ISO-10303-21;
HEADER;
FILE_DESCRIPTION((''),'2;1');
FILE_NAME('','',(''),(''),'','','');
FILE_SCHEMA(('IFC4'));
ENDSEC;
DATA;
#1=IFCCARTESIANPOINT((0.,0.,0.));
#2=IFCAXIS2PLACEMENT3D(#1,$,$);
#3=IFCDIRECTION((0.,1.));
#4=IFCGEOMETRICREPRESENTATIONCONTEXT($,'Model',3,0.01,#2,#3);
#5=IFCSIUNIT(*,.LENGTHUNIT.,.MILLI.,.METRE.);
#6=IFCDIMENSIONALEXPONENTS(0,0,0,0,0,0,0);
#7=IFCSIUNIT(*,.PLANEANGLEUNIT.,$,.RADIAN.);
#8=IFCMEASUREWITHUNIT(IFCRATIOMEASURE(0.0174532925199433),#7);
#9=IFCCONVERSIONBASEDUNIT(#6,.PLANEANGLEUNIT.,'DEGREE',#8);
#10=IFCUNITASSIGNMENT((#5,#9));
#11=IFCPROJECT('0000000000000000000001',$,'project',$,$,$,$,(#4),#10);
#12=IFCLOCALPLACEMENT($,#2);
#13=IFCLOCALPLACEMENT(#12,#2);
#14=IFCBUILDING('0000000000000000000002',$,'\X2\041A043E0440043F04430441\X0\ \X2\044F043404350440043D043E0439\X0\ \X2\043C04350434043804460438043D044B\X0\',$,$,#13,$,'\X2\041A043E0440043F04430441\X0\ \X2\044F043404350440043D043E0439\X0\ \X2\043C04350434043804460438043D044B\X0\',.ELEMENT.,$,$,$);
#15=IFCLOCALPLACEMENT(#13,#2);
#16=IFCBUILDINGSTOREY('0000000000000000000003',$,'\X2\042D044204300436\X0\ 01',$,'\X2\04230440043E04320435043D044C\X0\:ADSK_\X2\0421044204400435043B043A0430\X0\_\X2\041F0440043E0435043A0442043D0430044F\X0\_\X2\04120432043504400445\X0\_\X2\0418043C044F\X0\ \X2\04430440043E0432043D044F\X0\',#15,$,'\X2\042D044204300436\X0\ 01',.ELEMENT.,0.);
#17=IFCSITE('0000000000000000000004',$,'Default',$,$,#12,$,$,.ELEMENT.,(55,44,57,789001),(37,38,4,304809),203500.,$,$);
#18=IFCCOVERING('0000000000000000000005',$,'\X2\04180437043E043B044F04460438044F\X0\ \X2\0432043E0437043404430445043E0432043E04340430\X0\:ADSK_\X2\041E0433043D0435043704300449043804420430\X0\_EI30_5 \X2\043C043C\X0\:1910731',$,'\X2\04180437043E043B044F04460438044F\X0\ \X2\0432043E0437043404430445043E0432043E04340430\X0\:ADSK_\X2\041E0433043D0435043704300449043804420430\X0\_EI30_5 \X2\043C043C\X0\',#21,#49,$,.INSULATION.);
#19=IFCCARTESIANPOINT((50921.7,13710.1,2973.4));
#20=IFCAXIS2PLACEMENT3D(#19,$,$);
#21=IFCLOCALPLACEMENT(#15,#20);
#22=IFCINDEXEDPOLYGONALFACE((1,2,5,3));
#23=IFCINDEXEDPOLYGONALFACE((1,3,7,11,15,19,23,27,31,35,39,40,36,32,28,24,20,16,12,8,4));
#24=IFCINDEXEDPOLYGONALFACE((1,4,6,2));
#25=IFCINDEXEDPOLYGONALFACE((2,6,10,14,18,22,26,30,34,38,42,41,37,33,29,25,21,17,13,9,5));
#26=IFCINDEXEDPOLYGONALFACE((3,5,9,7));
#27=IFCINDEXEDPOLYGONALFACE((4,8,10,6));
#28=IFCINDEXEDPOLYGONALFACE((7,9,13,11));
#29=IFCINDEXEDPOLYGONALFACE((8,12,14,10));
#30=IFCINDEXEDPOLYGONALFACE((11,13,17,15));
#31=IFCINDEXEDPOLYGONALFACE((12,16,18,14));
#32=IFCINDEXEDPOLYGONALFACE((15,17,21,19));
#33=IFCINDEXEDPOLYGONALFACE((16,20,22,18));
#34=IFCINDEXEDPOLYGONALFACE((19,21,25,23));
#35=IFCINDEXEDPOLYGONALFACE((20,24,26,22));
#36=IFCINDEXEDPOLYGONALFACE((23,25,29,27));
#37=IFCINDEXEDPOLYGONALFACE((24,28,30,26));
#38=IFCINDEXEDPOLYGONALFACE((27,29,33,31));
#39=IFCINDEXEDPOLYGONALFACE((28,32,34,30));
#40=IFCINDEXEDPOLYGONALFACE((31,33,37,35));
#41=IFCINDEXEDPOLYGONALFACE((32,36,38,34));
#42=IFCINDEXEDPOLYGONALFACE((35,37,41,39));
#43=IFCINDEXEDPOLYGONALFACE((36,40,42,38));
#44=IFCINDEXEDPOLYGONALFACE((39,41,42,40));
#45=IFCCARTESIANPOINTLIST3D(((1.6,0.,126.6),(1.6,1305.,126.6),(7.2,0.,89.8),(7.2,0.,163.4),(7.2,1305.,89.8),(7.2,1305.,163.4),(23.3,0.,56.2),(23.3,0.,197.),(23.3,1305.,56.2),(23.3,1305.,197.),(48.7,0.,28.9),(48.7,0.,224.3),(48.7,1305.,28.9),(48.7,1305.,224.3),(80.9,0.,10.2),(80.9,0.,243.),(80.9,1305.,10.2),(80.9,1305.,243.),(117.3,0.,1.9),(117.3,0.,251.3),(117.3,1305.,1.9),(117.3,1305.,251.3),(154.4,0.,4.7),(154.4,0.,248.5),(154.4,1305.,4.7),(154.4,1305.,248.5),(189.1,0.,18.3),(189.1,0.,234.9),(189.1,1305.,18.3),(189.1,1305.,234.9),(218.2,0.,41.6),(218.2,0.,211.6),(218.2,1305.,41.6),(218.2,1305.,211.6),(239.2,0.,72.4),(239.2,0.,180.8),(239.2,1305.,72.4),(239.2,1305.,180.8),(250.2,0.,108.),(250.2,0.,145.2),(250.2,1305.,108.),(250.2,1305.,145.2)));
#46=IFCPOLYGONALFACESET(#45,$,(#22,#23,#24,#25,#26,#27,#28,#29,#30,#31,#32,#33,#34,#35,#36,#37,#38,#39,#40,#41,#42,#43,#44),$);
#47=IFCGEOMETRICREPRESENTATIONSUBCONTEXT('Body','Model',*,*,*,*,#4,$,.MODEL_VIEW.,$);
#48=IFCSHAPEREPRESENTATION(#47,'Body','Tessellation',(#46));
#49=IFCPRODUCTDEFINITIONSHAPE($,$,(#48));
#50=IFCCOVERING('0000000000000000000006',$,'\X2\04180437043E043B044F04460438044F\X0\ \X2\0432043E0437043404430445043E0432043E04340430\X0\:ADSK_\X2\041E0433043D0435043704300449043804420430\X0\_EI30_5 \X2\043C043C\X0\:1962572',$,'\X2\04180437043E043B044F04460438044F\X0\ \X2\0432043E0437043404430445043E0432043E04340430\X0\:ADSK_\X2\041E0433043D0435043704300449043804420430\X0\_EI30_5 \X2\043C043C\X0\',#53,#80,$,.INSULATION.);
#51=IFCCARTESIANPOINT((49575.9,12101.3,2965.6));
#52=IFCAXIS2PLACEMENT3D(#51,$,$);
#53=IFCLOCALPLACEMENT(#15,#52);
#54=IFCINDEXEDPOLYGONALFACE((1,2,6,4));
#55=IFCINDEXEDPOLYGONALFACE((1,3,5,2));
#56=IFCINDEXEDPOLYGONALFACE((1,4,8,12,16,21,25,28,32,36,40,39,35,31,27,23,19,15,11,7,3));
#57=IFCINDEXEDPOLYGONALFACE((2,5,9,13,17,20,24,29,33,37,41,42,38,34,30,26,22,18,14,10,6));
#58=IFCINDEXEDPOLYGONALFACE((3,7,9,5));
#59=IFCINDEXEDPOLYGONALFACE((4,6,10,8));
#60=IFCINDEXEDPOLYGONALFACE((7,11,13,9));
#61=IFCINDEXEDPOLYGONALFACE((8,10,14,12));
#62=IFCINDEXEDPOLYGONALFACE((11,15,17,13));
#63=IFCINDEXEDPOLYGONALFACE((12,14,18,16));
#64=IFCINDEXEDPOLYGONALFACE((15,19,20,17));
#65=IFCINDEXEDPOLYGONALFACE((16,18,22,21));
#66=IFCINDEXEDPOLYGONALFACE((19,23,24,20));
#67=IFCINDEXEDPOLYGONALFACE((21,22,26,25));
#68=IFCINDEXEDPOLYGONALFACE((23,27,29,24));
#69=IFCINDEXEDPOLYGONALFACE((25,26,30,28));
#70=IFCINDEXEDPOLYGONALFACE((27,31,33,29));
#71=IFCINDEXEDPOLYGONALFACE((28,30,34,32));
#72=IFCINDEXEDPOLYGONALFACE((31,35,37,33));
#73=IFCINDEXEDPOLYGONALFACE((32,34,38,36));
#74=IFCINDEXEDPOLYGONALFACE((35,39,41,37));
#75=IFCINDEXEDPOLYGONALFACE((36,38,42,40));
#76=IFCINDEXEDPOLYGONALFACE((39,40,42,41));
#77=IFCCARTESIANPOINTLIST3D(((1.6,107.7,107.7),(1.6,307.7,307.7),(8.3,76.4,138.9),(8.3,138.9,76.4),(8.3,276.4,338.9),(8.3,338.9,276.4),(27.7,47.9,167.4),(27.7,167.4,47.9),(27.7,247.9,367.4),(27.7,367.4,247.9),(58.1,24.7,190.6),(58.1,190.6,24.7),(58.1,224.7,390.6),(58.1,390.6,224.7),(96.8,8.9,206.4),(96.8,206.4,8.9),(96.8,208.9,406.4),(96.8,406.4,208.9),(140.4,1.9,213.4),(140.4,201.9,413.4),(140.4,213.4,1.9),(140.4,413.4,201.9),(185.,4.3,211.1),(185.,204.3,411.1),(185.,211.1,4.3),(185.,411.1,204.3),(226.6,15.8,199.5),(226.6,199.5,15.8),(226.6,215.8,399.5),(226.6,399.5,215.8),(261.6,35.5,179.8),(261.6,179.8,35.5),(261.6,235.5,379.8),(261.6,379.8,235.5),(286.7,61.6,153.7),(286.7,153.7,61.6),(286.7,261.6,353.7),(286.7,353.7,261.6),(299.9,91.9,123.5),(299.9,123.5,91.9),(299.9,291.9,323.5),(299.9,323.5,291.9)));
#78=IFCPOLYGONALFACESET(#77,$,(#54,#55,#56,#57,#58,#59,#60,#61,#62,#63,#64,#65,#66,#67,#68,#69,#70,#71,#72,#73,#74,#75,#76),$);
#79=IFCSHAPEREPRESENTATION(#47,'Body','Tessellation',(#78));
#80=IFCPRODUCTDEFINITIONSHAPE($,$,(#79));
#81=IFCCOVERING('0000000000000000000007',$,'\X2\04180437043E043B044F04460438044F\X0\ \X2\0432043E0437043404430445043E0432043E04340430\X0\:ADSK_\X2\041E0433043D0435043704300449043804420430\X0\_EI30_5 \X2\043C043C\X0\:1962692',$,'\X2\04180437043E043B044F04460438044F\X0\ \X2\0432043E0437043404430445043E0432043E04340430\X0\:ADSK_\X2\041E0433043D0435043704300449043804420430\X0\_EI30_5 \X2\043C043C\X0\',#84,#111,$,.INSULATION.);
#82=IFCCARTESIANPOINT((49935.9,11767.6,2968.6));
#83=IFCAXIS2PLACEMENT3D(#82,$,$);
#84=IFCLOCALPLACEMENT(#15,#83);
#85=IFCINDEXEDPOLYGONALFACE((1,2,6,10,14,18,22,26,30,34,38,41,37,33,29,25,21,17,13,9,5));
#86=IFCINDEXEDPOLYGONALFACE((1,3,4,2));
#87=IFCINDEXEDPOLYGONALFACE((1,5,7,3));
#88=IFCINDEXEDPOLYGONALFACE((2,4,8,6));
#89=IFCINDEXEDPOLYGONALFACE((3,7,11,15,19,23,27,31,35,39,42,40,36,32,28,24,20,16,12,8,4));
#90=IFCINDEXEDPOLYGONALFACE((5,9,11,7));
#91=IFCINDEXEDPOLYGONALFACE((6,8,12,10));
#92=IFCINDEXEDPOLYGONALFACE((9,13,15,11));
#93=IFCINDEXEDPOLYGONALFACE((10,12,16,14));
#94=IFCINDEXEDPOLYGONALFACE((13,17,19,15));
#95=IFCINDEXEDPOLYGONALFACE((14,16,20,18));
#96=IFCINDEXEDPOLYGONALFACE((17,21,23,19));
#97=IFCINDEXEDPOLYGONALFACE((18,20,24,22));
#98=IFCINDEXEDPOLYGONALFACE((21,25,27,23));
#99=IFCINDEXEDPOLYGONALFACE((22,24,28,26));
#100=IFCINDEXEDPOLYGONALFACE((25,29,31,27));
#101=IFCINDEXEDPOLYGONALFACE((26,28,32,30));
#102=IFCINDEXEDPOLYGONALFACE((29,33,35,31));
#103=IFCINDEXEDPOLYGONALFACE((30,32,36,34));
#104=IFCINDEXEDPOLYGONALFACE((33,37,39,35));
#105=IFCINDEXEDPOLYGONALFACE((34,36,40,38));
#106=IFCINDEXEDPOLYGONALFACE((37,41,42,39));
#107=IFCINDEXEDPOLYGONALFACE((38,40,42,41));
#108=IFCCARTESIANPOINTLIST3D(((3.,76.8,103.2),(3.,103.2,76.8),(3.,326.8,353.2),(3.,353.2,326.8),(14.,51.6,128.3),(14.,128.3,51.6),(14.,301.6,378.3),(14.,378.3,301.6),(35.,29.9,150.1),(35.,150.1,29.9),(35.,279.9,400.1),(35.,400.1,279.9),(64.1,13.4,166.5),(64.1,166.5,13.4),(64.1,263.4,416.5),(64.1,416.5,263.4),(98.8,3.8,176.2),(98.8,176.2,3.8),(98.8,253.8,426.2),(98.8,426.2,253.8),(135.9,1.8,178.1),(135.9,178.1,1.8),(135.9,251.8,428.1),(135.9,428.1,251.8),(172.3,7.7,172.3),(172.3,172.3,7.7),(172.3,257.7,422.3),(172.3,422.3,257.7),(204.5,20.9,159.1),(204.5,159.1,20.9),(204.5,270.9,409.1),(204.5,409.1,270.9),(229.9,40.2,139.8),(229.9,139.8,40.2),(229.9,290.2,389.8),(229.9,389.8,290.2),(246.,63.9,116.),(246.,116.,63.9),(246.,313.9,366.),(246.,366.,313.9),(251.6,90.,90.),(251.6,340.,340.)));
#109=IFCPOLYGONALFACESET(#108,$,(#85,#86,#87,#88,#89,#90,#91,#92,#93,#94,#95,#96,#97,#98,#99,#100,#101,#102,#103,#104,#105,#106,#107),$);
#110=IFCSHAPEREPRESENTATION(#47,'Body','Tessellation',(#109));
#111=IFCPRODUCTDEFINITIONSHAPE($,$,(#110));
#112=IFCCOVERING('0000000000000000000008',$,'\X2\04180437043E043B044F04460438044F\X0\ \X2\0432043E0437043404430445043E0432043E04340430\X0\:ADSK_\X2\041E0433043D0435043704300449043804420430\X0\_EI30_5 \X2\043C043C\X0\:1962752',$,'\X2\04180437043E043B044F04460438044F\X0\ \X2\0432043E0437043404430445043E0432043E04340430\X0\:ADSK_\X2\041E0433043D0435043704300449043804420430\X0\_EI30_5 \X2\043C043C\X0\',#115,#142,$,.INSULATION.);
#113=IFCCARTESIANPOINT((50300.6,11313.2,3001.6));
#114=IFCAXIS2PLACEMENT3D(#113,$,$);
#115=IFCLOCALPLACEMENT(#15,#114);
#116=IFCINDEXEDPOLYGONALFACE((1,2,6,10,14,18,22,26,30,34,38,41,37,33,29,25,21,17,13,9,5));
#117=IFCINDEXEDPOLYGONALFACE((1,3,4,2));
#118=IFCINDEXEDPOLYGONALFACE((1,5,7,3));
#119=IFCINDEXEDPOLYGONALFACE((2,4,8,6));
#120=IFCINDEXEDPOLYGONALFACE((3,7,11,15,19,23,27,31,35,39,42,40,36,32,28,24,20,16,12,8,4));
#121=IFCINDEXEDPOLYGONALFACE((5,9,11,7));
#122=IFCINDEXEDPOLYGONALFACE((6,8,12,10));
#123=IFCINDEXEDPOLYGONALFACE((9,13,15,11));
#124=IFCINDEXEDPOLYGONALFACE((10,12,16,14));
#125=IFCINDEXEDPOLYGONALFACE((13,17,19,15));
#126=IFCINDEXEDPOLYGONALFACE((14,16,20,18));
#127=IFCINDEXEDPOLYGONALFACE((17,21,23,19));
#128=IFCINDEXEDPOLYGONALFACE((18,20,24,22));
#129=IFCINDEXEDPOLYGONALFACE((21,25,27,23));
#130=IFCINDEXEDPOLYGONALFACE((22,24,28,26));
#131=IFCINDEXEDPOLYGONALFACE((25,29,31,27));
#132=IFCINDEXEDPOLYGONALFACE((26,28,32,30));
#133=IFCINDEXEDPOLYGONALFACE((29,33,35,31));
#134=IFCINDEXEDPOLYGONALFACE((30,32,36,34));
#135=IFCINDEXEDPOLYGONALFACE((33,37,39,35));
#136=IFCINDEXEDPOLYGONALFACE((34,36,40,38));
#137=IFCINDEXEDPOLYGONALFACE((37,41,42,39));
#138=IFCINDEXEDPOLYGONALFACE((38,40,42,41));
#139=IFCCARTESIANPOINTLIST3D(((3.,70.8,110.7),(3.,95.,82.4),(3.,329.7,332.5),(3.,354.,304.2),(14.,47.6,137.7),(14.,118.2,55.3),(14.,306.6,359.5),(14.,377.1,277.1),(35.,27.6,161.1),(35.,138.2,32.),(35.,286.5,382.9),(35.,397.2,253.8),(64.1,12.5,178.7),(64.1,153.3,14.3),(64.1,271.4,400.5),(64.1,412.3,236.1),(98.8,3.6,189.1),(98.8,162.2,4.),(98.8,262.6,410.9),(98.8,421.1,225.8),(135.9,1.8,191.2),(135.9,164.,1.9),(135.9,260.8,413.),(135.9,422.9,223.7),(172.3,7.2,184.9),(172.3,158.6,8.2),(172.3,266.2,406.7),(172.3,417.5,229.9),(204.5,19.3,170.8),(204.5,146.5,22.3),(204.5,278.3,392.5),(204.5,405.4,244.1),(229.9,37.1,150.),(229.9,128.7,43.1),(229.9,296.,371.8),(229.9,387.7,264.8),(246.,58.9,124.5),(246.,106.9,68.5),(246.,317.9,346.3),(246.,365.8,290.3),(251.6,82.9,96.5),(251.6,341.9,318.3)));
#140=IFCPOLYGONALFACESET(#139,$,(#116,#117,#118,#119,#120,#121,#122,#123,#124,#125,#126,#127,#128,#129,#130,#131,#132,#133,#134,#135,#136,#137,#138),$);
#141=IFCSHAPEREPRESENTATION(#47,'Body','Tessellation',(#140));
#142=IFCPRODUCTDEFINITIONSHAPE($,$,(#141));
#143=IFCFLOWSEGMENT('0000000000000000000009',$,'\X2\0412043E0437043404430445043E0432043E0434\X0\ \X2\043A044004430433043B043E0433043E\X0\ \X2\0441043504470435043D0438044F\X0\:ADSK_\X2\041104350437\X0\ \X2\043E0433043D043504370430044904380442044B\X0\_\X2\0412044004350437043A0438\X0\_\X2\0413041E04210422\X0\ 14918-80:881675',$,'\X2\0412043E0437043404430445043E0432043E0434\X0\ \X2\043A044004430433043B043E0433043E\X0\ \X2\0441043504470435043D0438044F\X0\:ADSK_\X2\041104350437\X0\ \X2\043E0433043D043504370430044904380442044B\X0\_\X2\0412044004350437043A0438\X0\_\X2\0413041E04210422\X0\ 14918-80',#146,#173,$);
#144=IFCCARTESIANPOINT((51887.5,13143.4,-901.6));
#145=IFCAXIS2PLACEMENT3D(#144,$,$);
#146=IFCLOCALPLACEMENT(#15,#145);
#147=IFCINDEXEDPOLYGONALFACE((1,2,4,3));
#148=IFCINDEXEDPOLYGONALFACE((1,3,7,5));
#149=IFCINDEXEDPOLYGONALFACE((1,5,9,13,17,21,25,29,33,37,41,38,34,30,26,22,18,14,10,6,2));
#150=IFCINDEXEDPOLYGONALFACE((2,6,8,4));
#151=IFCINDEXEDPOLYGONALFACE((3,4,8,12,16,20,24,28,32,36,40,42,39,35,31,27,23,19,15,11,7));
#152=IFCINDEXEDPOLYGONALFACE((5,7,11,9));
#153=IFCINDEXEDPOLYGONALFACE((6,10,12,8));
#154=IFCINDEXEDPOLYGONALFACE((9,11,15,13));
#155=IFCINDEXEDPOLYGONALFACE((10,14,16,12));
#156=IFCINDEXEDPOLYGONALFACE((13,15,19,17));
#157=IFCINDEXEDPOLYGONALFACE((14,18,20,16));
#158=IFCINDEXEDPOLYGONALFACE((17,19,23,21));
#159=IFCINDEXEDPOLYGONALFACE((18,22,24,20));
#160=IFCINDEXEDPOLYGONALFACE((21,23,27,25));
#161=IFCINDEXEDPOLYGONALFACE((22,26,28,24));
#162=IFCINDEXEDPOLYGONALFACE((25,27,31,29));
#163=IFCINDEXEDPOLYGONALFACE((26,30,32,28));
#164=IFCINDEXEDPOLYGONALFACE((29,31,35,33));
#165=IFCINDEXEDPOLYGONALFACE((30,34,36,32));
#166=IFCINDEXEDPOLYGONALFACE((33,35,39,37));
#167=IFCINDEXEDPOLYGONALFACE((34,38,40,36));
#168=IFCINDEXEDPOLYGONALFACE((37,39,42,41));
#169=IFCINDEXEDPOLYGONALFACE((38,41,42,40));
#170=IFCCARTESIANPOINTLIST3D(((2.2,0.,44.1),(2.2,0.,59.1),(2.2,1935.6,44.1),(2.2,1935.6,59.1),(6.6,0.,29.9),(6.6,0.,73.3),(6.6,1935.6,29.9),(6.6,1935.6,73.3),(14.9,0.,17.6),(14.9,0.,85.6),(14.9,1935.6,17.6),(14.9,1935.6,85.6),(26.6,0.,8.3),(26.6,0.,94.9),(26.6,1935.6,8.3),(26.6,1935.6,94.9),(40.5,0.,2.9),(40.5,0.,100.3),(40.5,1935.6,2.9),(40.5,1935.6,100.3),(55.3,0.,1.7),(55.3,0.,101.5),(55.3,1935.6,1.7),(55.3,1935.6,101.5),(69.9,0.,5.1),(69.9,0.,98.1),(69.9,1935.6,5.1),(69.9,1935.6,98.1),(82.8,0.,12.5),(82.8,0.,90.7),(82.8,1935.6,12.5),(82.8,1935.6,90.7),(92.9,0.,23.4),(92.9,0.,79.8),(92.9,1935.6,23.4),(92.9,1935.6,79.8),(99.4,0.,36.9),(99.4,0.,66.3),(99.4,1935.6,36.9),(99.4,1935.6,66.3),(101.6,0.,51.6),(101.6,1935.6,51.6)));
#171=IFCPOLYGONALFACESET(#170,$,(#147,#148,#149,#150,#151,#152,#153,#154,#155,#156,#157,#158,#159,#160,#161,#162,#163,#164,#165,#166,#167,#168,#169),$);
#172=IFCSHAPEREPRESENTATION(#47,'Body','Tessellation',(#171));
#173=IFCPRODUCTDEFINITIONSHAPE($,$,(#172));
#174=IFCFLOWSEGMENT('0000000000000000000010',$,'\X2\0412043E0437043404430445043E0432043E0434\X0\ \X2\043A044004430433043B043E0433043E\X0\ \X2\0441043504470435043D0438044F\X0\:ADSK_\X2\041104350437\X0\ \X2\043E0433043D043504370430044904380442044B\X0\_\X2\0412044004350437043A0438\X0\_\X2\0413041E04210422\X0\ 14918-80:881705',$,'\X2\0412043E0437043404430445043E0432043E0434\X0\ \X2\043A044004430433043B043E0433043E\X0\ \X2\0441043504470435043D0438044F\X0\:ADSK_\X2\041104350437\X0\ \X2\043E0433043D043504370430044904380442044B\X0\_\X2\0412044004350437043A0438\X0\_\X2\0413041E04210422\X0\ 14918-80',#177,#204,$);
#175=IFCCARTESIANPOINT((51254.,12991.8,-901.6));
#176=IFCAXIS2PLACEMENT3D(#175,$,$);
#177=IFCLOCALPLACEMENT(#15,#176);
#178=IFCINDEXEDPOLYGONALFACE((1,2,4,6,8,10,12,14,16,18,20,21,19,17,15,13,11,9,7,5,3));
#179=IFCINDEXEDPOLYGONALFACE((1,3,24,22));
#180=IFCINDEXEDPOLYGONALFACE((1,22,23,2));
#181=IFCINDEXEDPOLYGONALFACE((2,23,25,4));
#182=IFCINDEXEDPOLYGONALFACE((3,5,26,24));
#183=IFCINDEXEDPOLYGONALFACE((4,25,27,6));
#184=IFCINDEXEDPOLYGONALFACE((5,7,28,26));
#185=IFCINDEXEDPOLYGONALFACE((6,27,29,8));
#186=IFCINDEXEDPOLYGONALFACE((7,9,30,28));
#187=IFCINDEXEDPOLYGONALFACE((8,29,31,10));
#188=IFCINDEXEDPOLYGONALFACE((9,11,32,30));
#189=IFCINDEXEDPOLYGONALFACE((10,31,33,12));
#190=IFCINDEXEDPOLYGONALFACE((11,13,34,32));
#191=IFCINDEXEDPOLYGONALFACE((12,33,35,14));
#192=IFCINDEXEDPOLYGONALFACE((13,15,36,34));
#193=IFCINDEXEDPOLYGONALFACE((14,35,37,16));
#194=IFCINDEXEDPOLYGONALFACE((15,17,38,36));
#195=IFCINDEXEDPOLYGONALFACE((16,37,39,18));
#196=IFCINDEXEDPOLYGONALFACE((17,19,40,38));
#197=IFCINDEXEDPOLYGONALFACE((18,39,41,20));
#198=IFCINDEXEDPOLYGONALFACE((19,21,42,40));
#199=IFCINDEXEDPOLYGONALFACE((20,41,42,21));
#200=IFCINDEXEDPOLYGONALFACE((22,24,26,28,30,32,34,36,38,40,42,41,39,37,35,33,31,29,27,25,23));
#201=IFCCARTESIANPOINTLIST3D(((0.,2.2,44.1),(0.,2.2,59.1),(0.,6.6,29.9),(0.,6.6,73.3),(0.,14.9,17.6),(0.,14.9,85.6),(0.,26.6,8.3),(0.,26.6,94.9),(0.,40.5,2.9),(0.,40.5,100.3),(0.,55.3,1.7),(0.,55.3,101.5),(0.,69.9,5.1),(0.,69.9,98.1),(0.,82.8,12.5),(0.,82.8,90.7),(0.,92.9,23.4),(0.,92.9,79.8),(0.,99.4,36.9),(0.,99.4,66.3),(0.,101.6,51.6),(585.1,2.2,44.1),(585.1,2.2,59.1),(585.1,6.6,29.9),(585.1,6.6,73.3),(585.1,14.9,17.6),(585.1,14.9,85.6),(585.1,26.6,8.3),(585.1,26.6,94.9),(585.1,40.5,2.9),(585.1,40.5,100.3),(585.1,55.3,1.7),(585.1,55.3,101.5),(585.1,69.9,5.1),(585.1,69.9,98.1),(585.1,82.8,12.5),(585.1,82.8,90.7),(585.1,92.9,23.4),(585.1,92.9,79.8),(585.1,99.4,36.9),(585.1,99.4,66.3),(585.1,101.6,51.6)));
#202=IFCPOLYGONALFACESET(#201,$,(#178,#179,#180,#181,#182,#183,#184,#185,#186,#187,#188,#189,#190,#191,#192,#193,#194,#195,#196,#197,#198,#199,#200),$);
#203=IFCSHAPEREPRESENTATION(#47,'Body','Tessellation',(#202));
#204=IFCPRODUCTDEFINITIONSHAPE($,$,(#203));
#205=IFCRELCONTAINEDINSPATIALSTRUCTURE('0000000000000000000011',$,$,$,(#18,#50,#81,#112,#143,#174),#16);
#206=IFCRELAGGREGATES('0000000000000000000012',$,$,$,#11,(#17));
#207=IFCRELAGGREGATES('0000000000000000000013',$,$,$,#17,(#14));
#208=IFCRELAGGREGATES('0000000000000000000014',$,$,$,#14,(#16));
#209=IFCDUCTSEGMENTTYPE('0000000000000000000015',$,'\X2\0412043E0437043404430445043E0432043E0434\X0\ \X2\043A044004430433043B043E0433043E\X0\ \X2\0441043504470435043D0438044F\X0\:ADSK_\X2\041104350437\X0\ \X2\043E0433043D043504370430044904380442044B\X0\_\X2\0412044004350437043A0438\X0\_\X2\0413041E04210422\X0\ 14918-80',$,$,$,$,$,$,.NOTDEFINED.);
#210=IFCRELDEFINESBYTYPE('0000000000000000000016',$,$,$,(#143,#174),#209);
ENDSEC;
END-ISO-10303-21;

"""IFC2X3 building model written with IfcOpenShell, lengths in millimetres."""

from ifc_helpers import new_model, entity, si_unit, converted_unit, direction, frame, origin, origin_2d_with_axis, place, context, subcontext, project, spatial, circle, extrude, type_object, element, save


model = new_model("IFC2X3")

# Units and contexts
model_context = context("Model", 3, precision=0.01, world=origin(), true_north=direction((0.0, 1.0)))
body_context = subcontext(model_context, "Body", "Model", "MODEL_VIEW")
ifc_project = project(units=[si_unit("LENGTHUNIT", "METRE", prefix="MILLI"), converted_unit("PLANEANGLEUNIT", "DEGREE", entity("IfcRatioMeasure", 0.0174532925199433), si_unit("PLANEANGLEUNIT", "RADIAN"), dimensions=[0, 0, 0, 0, 0, 0, 0])], contexts=[model_context])

# Site, building, storey
site_placement = place(None, origin())
site = spatial("IfcSite", under=ifc_project, at=site_placement, Name="Default", CompositionType="ELEMENT", RefLatitude=(55, 44, 57, 789001), RefLongitude=(37, 38, 4, 304809), RefElevation=203500.0)
building_placement = place(site_placement, origin())
building = spatial("IfcBuilding", under=site, at=building_placement, Name="Корпус ядерной медицины", LongName="Корпус ядерной медицины", CompositionType="ELEMENT")
storey_placement = place(building_placement, origin())
storey = spatial("IfcBuildingStorey", under=building, at=storey_placement, Name="Этаж 01", ObjectType="Уровень:ADSK_Стрелка_Проектная_Вверх_Имя уровня", LongName="Этаж 01", CompositionType="ELEMENT", Elevation=0.0)

# Coverings
covering_1_placement = place(storey_placement, frame((50921.7, 13710.1, 2973.4)))
element("IfcCovering", 1, at=covering_1_placement, inside=storey, Name="Изоляция воздуховода:ADSK_Огнезащита_EI30_5 мм:1910731", ObjectType="Изоляция воздуховода:ADSK_Огнезащита_EI30_5 мм", PredefinedType="INSULATION", context=body_context, shape_type="SweptSolid", body=[
    extrude(circle(Radius=125.0, at=origin_2d_with_axis()), frame((126.6, 0.0, 126.6), z_axis=(0.0, 1.0, 0.0), x_axis=(-1.0, 0.0, 0.0)), (0.0, 0.0, 1.0), 1305.0),
])
covering_2_placement = place(storey_placement, frame((49575.9, 12101.3, 2965.6)))
element("IfcCovering", 2, at=covering_2_placement, inside=storey, Name="Изоляция воздуховода:ADSK_Огнезащита_EI30_5 мм:1962572", ObjectType="Изоляция воздуховода:ADSK_Огнезащита_EI30_5 мм", PredefinedType="INSULATION", context=body_context, shape_type="SweptSolid", body=[
    extrude(circle(Radius=150.0, at=origin_2d_with_axis()), frame((151.6, 107.7, 107.7), z_axis=(0.0, 0.707107, 0.707107), x_axis=(-1.0, 0.0, 0.0)), (0.0, 0.0, 1.0), 282.8),
])
covering_3_placement = place(storey_placement, frame((49935.9, 11767.6, 2968.6)))
element("IfcCovering", 3, at=covering_3_placement, inside=storey, Name="Изоляция воздуховода:ADSK_Огнезащита_EI30_5 мм:1962692", ObjectType="Изоляция воздуховода:ADSK_Огнезащита_EI30_5 мм", PredefinedType="INSULATION", context=body_context, shape_type="SweptSolid", body=[
    extrude(circle(Radius=125.0, at=origin_2d_with_axis()), frame((126.6, 90.0, 90.0), z_axis=(0.0, 0.707107, 0.707107), x_axis=(1.0, 0.0, 0.0)), (0.0, 0.0, 1.0), 353.6),
])
covering_4_placement = place(storey_placement, frame((50300.6, 11313.2, 3001.6)))
element("IfcCovering", 4, at=covering_4_placement, inside=storey, Name="Изоляция воздуховода:ADSK_Огнезащита_EI30_5 мм:1962752", ObjectType="Изоляция воздуховода:ADSK_Огнезащита_EI30_5 мм", PredefinedType="INSULATION", context=body_context, shape_type="SweptSolid", body=[
    extrude(circle(Radius=125.0, at=origin_2d_with_axis()), frame((126.6, 82.9, 96.5), z_axis=(0.0, 0.759487, 0.650522), x_axis=(1.0, 0.0, 0.0)), (0.0, 0.0, 1.0), 340.9),
])

# Flow segments
duct_segment_type_1 = type_object("IfcDuctSegmentType", Name="Воздуховод круглого сечения:ADSK_Без огнезащиты_Врезки_ГОСТ 14918-80", PredefinedType="NOTDEFINED")
flow_segment_1_placement = place(storey_placement, frame((51887.5, 13143.4, -901.6)))
element("IfcFlowSegment", 5, at=flow_segment_1_placement, inside=storey, type_object=duct_segment_type_1, Name="Воздуховод круглого сечения:ADSK_Без огнезащиты_Врезки_ГОСТ 14918-80:881675", ObjectType="Воздуховод круглого сечения:ADSK_Без огнезащиты_Врезки_ГОСТ 14918-80", context=body_context, shape_type="SweptSolid", body=[
    extrude(circle(Radius=50.0, at=origin_2d_with_axis()), frame((51.6, 0.0, 51.6), z_axis=(0.0, 1.0, 0.0), x_axis=(1.0, 0.0, 0.0)), (0.0, 0.0, 1.0), 1935.6),
])
flow_segment_2_placement = place(storey_placement, frame((51254.0, 12991.8, -901.6)))
element("IfcFlowSegment", 6, at=flow_segment_2_placement, inside=storey, type_object=duct_segment_type_1, Name="Воздуховод круглого сечения:ADSK_Без огнезащиты_Врезки_ГОСТ 14918-80:881705", ObjectType="Воздуховод круглого сечения:ADSK_Без огнезащиты_Врезки_ГОСТ 14918-80", context=body_context, shape_type="SweptSolid", body=[
    extrude(circle(Radius=50.0, at=origin_2d_with_axis()), frame((0.0, 51.6, 51.6), z_axis=(1.0, 0.0, 0.0), x_axis=(0.0, 1.0, 0.0)), (0.0, 0.0, 1.0), 585.1),
])

save(model, "model.ifc")
